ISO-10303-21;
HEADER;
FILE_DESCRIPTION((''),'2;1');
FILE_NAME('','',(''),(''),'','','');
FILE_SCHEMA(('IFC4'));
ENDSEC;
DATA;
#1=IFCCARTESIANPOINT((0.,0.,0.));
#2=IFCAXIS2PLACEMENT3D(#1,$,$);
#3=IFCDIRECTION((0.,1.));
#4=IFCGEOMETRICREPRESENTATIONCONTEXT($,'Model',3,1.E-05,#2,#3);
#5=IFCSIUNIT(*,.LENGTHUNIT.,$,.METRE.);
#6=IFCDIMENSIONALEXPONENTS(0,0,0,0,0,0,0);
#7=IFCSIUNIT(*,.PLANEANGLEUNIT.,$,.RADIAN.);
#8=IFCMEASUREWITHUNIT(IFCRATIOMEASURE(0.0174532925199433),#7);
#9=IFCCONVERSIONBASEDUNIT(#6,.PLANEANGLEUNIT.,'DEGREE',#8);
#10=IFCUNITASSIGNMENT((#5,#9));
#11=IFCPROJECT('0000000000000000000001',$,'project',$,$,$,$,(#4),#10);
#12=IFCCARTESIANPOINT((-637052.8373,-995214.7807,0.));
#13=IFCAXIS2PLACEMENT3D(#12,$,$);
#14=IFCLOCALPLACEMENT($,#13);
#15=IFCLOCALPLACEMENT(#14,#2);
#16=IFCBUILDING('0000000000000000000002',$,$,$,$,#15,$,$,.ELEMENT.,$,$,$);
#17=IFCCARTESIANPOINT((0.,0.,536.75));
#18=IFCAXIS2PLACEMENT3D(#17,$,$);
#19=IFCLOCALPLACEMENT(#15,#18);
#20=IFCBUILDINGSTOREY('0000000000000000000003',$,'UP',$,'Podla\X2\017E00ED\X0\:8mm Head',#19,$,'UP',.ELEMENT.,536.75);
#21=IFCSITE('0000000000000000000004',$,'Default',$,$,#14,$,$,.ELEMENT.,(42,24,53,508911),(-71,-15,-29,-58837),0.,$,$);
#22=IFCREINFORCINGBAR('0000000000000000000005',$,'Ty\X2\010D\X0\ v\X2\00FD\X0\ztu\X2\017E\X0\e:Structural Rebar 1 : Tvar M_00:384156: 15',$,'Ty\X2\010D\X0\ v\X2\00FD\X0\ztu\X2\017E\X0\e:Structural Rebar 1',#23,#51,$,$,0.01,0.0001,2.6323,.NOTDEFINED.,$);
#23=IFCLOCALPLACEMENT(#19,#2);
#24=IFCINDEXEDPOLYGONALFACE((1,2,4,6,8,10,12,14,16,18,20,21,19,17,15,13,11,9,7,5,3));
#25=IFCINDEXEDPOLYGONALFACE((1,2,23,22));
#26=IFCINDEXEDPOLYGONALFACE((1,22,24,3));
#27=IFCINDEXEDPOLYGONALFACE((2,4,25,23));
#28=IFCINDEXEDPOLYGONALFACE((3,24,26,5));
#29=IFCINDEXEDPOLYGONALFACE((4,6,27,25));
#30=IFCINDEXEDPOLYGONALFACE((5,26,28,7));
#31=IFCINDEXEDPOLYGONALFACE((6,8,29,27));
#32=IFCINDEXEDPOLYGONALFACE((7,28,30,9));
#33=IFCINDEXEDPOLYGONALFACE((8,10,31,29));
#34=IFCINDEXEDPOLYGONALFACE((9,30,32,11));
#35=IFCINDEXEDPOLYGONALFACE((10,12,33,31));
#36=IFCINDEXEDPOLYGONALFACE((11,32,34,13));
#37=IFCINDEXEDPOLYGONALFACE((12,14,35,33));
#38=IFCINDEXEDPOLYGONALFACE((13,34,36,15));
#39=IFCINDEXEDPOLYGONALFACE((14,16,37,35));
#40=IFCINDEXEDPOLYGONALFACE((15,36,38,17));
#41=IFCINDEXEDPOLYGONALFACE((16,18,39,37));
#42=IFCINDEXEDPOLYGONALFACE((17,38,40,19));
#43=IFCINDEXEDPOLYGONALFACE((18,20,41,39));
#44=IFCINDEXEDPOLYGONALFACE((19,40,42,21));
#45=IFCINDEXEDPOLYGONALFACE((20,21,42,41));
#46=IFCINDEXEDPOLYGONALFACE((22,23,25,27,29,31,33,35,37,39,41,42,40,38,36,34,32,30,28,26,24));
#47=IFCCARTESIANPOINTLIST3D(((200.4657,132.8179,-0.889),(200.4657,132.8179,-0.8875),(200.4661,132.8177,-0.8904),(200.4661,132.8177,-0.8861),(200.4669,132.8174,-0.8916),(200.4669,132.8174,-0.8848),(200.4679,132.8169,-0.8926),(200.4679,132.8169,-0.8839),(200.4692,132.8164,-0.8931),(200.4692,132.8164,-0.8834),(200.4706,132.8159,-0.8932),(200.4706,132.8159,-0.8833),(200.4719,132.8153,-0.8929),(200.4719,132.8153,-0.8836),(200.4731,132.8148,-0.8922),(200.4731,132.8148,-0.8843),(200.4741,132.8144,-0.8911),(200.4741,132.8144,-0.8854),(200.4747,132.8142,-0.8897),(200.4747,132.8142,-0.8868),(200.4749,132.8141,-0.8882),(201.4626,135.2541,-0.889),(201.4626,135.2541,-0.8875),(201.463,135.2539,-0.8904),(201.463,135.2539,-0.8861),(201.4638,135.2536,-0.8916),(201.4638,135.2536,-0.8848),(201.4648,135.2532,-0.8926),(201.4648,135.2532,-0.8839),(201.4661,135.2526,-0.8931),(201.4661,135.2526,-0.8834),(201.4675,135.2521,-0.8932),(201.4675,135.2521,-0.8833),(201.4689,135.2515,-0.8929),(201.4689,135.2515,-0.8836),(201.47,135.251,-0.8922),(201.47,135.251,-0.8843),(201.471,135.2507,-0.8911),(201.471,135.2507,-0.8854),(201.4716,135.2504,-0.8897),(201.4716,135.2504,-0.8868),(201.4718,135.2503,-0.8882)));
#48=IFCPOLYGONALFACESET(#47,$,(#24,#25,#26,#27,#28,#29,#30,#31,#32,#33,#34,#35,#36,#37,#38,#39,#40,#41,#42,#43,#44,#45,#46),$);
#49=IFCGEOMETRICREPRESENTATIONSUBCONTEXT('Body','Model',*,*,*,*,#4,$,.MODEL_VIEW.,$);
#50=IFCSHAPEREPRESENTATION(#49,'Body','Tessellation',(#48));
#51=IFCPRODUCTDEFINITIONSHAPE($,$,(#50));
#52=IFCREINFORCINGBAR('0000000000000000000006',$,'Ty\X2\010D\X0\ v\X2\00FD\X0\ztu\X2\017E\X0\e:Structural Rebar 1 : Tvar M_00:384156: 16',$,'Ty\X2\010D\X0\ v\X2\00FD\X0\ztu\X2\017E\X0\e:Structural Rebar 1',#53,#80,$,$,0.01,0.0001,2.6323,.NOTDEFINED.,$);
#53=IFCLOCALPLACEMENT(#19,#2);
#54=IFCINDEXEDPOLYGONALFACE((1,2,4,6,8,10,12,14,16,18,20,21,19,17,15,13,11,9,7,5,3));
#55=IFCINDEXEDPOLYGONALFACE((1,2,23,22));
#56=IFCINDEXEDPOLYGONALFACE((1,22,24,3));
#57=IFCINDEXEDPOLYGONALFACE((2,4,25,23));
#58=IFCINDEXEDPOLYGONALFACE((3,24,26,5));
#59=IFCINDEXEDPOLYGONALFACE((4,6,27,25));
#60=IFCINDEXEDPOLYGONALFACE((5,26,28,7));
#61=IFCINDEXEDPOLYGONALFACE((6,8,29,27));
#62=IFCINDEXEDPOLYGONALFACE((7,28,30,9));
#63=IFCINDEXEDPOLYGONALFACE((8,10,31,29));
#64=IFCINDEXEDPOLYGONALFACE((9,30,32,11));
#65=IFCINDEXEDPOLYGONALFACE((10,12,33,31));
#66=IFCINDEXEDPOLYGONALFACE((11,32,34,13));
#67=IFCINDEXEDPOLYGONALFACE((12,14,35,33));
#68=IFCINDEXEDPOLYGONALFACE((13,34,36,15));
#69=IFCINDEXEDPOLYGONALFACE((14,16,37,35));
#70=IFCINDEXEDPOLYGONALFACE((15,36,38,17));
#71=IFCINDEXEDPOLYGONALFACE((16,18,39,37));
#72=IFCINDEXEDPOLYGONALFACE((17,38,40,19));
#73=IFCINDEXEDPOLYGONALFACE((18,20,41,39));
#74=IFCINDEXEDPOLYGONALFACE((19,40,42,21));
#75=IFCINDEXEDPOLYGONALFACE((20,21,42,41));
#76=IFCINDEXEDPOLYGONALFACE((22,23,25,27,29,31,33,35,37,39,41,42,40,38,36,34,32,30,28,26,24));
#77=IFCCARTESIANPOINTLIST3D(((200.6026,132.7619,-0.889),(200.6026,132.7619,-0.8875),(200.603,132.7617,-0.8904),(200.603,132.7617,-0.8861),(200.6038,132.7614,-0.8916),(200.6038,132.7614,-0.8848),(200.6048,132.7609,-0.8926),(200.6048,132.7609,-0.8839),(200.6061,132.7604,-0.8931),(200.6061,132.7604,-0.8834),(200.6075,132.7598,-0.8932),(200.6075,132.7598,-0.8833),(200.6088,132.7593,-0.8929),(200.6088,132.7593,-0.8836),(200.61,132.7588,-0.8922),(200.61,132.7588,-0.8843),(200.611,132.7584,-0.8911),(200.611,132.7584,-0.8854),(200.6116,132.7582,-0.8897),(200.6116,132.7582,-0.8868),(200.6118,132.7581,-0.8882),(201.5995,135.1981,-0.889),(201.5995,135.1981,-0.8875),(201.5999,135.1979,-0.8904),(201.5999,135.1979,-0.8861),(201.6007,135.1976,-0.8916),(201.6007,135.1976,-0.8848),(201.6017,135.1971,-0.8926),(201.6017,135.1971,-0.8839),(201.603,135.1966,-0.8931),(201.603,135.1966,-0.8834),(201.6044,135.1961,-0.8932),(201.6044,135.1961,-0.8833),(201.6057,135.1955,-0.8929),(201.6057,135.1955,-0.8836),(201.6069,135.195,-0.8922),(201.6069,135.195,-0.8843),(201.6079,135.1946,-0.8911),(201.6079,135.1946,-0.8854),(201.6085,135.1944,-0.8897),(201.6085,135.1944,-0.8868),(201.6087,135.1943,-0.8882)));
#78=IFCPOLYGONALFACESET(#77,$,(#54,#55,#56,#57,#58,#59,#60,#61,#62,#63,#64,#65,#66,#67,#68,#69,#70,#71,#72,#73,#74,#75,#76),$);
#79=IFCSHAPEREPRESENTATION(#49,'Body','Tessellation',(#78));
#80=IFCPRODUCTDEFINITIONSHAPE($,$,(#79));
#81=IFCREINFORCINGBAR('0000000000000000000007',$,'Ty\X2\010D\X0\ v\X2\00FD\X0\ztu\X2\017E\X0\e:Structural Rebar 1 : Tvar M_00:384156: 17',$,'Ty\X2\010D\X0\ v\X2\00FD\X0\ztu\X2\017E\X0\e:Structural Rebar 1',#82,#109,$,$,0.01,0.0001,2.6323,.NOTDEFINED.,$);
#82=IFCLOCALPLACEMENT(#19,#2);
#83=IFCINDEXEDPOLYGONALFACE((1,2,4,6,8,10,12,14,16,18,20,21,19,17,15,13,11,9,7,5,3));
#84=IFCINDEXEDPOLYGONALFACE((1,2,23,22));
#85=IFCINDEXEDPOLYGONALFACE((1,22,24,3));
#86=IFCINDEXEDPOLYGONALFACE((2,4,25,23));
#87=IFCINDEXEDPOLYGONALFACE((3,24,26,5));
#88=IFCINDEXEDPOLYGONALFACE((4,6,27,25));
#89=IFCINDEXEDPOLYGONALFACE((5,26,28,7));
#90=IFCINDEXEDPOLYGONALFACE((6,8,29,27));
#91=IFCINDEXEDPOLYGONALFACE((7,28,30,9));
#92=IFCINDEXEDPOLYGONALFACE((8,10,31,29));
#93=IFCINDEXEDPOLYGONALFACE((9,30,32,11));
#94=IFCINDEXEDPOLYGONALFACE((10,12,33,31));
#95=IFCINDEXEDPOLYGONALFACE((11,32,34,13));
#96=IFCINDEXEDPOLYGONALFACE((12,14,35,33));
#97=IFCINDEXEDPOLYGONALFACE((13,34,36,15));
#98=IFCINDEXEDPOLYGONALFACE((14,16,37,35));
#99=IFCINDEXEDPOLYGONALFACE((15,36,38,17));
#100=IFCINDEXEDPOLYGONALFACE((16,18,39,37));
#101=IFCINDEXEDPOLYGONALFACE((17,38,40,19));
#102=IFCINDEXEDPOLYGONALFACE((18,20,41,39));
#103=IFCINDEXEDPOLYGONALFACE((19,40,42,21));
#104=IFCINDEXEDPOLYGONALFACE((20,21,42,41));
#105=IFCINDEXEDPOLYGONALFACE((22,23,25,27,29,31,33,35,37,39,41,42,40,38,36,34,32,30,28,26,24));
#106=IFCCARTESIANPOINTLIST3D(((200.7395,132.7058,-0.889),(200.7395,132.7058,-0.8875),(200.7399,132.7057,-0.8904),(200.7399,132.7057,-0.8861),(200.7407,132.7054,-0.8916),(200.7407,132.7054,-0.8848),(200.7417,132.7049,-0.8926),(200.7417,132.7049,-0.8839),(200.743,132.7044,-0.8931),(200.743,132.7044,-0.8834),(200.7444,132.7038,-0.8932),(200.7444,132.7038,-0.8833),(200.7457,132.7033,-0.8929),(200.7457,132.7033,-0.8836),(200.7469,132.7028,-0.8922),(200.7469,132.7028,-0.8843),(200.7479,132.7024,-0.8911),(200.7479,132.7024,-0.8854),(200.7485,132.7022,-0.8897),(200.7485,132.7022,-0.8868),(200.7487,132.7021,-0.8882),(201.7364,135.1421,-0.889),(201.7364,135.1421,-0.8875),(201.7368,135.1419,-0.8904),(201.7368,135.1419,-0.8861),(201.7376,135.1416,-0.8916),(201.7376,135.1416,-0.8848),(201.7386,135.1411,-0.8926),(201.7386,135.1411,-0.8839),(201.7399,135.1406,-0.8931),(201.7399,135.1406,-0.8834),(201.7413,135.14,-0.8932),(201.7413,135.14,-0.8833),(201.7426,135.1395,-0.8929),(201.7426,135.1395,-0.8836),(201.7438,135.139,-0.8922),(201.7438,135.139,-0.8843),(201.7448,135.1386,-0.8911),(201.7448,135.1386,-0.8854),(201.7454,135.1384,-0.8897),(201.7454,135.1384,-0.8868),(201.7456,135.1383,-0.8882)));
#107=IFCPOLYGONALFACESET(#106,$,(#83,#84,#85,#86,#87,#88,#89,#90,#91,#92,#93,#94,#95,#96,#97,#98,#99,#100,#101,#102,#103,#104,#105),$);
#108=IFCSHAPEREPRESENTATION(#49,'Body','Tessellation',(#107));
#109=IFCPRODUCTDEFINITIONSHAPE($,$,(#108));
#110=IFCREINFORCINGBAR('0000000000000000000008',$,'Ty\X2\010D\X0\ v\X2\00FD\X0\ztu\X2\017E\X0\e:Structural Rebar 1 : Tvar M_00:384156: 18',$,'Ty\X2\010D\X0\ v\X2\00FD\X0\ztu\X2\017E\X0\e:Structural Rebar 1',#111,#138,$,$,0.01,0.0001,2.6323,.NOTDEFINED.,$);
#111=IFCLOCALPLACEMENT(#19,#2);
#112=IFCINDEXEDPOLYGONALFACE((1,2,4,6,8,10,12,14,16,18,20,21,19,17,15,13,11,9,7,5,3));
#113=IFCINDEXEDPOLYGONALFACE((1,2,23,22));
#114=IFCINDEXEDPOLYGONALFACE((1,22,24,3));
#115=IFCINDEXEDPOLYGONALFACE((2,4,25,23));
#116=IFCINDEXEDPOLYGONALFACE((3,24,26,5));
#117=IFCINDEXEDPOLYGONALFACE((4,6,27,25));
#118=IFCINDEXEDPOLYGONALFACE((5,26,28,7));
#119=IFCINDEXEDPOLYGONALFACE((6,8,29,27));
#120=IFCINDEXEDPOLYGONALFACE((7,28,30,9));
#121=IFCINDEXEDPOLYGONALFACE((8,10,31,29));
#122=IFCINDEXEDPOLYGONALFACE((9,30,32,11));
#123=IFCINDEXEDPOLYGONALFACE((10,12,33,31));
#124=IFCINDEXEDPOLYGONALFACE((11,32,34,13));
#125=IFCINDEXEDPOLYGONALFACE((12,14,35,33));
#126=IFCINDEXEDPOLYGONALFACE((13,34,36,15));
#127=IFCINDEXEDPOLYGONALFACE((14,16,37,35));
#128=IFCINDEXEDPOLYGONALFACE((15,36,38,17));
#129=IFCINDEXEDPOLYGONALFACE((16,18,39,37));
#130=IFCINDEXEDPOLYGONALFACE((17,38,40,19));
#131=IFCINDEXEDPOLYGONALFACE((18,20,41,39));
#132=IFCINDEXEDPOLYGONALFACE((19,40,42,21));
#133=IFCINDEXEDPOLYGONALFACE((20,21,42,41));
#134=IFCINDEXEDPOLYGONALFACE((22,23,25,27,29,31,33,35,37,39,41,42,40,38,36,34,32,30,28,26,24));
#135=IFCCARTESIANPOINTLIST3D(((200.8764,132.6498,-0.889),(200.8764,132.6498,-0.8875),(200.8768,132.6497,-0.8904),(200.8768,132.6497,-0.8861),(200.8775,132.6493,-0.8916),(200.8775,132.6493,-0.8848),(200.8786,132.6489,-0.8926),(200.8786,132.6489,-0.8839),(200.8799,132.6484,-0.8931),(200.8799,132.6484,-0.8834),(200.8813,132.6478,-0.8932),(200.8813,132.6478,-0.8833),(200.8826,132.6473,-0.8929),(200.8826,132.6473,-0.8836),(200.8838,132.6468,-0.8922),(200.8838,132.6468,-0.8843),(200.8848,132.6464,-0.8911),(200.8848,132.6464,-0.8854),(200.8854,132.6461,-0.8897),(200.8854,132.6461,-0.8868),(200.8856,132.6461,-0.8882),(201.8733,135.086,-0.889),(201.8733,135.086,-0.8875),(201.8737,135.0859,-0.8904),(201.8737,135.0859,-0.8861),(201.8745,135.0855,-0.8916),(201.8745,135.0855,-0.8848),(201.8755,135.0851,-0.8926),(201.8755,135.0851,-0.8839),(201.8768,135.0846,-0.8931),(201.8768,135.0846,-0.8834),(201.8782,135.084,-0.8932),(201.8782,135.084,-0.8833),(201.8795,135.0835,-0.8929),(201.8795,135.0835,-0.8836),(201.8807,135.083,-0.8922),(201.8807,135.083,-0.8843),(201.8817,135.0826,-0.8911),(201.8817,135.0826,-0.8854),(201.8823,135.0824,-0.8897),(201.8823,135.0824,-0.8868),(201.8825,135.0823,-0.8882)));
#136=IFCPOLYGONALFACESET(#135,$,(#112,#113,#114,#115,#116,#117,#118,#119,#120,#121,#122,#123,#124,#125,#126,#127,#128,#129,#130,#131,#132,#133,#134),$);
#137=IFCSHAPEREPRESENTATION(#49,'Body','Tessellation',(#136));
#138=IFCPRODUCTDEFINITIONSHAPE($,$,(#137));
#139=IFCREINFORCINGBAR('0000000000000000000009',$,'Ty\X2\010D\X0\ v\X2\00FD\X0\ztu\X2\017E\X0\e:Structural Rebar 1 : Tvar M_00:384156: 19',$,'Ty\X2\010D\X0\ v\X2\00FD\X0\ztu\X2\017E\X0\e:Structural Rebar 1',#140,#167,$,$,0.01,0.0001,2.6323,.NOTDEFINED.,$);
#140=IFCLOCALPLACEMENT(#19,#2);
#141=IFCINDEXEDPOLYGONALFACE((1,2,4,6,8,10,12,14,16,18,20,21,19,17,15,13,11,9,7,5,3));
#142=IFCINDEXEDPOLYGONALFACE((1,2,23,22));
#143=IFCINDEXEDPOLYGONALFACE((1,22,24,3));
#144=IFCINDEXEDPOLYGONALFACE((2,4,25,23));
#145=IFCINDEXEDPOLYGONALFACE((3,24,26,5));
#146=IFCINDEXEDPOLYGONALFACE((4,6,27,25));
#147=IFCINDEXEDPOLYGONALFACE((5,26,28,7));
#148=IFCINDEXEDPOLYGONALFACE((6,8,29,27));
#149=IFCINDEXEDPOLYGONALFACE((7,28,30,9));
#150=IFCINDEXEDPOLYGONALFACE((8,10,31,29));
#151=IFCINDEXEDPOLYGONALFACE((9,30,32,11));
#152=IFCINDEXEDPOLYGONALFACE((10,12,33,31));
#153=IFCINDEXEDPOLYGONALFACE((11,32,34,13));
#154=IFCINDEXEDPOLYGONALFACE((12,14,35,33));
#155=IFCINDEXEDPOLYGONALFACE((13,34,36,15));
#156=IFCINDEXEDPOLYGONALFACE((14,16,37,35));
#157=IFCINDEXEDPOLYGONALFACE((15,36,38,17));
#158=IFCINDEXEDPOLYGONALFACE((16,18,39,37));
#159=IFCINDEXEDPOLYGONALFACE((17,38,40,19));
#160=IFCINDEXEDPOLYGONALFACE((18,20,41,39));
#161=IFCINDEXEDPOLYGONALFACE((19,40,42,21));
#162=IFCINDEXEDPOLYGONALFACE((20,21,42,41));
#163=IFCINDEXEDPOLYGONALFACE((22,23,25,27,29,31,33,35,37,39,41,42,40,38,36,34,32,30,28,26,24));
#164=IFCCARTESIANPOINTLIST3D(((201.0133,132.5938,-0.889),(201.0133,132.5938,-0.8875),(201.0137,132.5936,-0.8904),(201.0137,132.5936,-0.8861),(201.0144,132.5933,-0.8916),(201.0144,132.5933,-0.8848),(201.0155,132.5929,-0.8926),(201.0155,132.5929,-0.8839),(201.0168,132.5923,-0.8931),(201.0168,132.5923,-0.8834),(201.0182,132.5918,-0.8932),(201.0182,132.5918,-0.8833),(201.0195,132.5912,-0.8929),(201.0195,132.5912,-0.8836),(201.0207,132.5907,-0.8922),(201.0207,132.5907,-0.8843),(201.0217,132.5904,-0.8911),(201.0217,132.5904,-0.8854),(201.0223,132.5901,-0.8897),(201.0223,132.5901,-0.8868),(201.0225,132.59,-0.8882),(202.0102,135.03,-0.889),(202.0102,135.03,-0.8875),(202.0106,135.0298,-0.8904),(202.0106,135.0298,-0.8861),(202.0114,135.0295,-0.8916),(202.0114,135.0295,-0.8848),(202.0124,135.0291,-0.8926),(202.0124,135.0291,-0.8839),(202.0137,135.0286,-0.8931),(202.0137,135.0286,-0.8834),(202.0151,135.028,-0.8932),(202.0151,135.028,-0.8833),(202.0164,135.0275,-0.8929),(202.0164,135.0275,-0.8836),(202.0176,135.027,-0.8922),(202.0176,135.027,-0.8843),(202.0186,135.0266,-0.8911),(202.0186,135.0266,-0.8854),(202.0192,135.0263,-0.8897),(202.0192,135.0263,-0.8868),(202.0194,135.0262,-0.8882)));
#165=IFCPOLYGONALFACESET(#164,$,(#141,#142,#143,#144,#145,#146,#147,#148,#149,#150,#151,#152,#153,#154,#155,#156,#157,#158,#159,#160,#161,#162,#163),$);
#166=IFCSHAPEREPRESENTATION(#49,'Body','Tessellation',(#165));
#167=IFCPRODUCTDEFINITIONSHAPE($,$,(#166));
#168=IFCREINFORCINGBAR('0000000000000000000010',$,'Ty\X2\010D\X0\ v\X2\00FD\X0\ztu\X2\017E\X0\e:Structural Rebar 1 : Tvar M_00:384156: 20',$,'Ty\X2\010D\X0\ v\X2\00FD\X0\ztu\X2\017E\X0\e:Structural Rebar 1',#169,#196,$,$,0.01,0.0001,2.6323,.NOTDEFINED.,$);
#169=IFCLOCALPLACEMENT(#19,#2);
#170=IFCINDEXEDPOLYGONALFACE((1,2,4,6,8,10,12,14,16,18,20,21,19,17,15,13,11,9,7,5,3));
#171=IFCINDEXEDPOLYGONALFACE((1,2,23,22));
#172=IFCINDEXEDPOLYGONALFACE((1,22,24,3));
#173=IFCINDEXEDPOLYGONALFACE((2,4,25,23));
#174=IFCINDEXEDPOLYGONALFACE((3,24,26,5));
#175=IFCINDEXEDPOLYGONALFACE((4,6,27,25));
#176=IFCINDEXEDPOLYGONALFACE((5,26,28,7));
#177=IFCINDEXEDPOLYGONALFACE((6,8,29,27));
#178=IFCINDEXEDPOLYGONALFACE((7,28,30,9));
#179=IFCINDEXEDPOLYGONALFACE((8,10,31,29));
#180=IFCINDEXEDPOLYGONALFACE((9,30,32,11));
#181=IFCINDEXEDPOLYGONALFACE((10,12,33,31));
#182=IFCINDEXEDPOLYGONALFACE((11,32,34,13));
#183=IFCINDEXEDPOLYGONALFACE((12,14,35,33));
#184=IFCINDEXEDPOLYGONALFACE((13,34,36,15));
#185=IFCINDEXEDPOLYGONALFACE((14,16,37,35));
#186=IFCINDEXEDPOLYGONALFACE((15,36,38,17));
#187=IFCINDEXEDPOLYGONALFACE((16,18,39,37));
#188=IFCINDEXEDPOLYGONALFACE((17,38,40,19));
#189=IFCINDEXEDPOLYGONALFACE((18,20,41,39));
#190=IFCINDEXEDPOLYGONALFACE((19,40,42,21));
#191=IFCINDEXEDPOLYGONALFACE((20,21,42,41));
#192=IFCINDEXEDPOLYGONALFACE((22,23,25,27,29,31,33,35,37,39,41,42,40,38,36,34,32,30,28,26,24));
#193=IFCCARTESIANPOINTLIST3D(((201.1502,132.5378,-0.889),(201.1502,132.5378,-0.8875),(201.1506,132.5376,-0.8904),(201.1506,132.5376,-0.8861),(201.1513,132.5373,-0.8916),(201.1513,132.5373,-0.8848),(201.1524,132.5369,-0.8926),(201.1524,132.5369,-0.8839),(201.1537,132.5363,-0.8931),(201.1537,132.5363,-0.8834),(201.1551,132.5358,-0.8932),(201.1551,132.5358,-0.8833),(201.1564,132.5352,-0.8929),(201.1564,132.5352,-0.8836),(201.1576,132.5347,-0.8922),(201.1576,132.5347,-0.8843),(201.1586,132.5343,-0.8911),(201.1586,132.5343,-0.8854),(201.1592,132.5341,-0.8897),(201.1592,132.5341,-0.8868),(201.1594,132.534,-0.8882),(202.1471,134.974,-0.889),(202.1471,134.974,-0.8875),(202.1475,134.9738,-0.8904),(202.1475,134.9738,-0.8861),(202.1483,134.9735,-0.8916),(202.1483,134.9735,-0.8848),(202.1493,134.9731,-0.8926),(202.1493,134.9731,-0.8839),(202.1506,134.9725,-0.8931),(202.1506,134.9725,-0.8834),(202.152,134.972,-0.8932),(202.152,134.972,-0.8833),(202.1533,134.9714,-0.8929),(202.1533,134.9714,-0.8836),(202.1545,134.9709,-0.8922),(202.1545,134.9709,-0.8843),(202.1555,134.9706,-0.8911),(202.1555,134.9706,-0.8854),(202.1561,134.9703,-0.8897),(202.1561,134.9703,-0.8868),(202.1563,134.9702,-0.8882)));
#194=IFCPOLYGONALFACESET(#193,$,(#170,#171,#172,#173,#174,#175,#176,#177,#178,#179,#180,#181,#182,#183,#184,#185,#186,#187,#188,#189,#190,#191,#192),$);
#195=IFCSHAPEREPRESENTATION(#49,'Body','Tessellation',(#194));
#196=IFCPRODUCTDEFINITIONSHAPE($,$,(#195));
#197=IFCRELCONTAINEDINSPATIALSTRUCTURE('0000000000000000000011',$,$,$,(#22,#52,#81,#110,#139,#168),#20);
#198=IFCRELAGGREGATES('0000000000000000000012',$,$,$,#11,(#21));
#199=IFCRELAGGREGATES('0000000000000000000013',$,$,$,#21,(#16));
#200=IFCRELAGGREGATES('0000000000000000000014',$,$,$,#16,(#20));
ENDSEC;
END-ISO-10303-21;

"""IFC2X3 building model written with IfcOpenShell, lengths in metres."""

from ifc_helpers import new_model, entity, si_unit, converted_unit, direction, frame, origin, place, context, subcontext, project, spatial, element, save


model = new_model("IFC2X3")

# Units and contexts
model_context = context("Model", 3, precision=1e-05, world=origin(), true_north=direction((0.0, 1.0)))
body_context = subcontext(model_context, "Body", "Model", "MODEL_VIEW")
ifc_project = project(units=[si_unit("LENGTHUNIT", "METRE"), converted_unit("PLANEANGLEUNIT", "DEGREE", entity("IfcRatioMeasure", 0.0174532925199433), si_unit("PLANEANGLEUNIT", "RADIAN"), dimensions=[0, 0, 0, 0, 0, 0, 0])], contexts=[model_context])

# Site, building, storey
site_placement = place(None, frame((-637052.8373, -995214.7807, 0.0)))
site = spatial("IfcSite", under=ifc_project, at=site_placement, Name="Default", CompositionType="ELEMENT", RefLatitude=(42, 24, 53, 508911), RefLongitude=(-71, -15, -29, -58837), RefElevation=0.0)
building_placement = place(site_placement, origin())
building = spatial("IfcBuilding", under=site, at=building_placement, CompositionType="ELEMENT")
storey_placement = place(building_placement, frame((0.0, 0.0, 536.75)))
storey = spatial("IfcBuildingStorey", under=building, at=storey_placement, Name="UP", ObjectType="Podlaží:8mm Head", LongName="UP", CompositionType="ELEMENT", Elevation=536.75)

# Reinforcing bars
reinforcing_bar_1_placement = place(storey_placement, origin())
element("IfcReinforcingBar", 1, at=reinforcing_bar_1_placement, inside=storey, Name="Tyč výztuže:Structural Rebar 1 : Tvar M_00:384156: 15", ObjectType="Tyč výztuže:Structural Rebar 1", BarLength=2.6323, BarRole="NOTDEFINED", CrossSectionArea=0.0001, NominalDiameter=0.01, context=body_context, shape_type="AdvancedSweptSolid", body=[
    entity("IfcSweptDiskSolid", entity("IfcCompositeCurve", [entity("IfcCompositeCurveSegment", "CONTINUOUS", True, entity("IfcPolyline", [entity("IfcCartesianPoint", [-201.4672, -135.2522, 0.8882]), entity("IfcCartesianPoint", [-200.4703, -132.816, 0.8882])]))], False), 0.005, None, 0.0, 1.0),
])
reinforcing_bar_2_placement = place(storey_placement, origin())
element("IfcReinforcingBar", 2, at=reinforcing_bar_2_placement, inside=storey, Name="Tyč výztuže:Structural Rebar 1 : Tvar M_00:384156: 16", ObjectType="Tyč výztuže:Structural Rebar 1", BarLength=2.6323, BarRole="NOTDEFINED", CrossSectionArea=0.0001, NominalDiameter=0.01, context=body_context, shape_type="AdvancedSweptSolid", body=[
    entity("IfcSweptDiskSolid", entity("IfcCompositeCurve", [entity("IfcCompositeCurveSegment", "CONTINUOUS", True, entity("IfcPolyline", [entity("IfcCartesianPoint", [-201.6041, -135.1962, 0.8882]), entity("IfcCartesianPoint", [-200.6071, -132.76, 0.8882])]))], False), 0.005, None, 0.0, 1.0),
])
reinforcing_bar_3_placement = place(storey_placement, origin())
element("IfcReinforcingBar", 3, at=reinforcing_bar_3_placement, inside=storey, Name="Tyč výztuže:Structural Rebar 1 : Tvar M_00:384156: 17", ObjectType="Tyč výztuže:Structural Rebar 1", BarLength=2.6323, BarRole="NOTDEFINED", CrossSectionArea=0.0001, NominalDiameter=0.01, context=body_context, shape_type="AdvancedSweptSolid", body=[
    entity("IfcSweptDiskSolid", entity("IfcCompositeCurve", [entity("IfcCompositeCurveSegment", "CONTINUOUS", True, entity("IfcPolyline", [entity("IfcCartesianPoint", [-201.741, -135.1402, 0.8882]), entity("IfcCartesianPoint", [-200.744, -132.704, 0.8882])]))], False), 0.005, None, 0.0, 1.0),
])
reinforcing_bar_4_placement = place(storey_placement, origin())
element("IfcReinforcingBar", 4, at=reinforcing_bar_4_placement, inside=storey, Name="Tyč výztuže:Structural Rebar 1 : Tvar M_00:384156: 18", ObjectType="Tyč výztuže:Structural Rebar 1", BarLength=2.6323, BarRole="NOTDEFINED", CrossSectionArea=0.0001, NominalDiameter=0.01, context=body_context, shape_type="AdvancedSweptSolid", body=[
    entity("IfcSweptDiskSolid", entity("IfcCompositeCurve", [entity("IfcCompositeCurveSegment", "CONTINUOUS", True, entity("IfcPolyline", [entity("IfcCartesianPoint", [-201.8778, -135.0842, 0.8882]), entity("IfcCartesianPoint", [-200.8809, -132.6479, 0.8882])]))], False), 0.005, None, 0.0, 1.0),
])
reinforcing_bar_5_placement = place(storey_placement, origin())
element("IfcReinforcingBar", 5, at=reinforcing_bar_5_placement, inside=storey, Name="Tyč výztuže:Structural Rebar 1 : Tvar M_00:384156: 19", ObjectType="Tyč výztuže:Structural Rebar 1", BarLength=2.6323, BarRole="NOTDEFINED", CrossSectionArea=0.0001, NominalDiameter=0.01, context=body_context, shape_type="AdvancedSweptSolid", body=[
    entity("IfcSweptDiskSolid", entity("IfcCompositeCurve", [entity("IfcCompositeCurveSegment", "CONTINUOUS", True, entity("IfcPolyline", [entity("IfcCartesianPoint", [-202.0147, -135.0281, 0.8882]), entity("IfcCartesianPoint", [-201.0178, -132.5919, 0.8882])]))], False), 0.005, None, 0.0, 1.0),
])
reinforcing_bar_6_placement = place(storey_placement, origin())
element("IfcReinforcingBar", 6, at=reinforcing_bar_6_placement, inside=storey, Name="Tyč výztuže:Structural Rebar 1 : Tvar M_00:384156: 20", ObjectType="Tyč výztuže:Structural Rebar 1", BarLength=2.6323, BarRole="NOTDEFINED", CrossSectionArea=0.0001, NominalDiameter=0.01, context=body_context, shape_type="AdvancedSweptSolid", body=[
    entity("IfcSweptDiskSolid", entity("IfcCompositeCurve", [entity("IfcCompositeCurveSegment", "CONTINUOUS", True, entity("IfcPolyline", [entity("IfcCartesianPoint", [-202.1516, -134.9721, 0.8882]), entity("IfcCartesianPoint", [-201.1547, -132.5359, 0.8882])]))], False), 0.005, None, 0.0, 1.0),
])

save(model, "model.ifc")
